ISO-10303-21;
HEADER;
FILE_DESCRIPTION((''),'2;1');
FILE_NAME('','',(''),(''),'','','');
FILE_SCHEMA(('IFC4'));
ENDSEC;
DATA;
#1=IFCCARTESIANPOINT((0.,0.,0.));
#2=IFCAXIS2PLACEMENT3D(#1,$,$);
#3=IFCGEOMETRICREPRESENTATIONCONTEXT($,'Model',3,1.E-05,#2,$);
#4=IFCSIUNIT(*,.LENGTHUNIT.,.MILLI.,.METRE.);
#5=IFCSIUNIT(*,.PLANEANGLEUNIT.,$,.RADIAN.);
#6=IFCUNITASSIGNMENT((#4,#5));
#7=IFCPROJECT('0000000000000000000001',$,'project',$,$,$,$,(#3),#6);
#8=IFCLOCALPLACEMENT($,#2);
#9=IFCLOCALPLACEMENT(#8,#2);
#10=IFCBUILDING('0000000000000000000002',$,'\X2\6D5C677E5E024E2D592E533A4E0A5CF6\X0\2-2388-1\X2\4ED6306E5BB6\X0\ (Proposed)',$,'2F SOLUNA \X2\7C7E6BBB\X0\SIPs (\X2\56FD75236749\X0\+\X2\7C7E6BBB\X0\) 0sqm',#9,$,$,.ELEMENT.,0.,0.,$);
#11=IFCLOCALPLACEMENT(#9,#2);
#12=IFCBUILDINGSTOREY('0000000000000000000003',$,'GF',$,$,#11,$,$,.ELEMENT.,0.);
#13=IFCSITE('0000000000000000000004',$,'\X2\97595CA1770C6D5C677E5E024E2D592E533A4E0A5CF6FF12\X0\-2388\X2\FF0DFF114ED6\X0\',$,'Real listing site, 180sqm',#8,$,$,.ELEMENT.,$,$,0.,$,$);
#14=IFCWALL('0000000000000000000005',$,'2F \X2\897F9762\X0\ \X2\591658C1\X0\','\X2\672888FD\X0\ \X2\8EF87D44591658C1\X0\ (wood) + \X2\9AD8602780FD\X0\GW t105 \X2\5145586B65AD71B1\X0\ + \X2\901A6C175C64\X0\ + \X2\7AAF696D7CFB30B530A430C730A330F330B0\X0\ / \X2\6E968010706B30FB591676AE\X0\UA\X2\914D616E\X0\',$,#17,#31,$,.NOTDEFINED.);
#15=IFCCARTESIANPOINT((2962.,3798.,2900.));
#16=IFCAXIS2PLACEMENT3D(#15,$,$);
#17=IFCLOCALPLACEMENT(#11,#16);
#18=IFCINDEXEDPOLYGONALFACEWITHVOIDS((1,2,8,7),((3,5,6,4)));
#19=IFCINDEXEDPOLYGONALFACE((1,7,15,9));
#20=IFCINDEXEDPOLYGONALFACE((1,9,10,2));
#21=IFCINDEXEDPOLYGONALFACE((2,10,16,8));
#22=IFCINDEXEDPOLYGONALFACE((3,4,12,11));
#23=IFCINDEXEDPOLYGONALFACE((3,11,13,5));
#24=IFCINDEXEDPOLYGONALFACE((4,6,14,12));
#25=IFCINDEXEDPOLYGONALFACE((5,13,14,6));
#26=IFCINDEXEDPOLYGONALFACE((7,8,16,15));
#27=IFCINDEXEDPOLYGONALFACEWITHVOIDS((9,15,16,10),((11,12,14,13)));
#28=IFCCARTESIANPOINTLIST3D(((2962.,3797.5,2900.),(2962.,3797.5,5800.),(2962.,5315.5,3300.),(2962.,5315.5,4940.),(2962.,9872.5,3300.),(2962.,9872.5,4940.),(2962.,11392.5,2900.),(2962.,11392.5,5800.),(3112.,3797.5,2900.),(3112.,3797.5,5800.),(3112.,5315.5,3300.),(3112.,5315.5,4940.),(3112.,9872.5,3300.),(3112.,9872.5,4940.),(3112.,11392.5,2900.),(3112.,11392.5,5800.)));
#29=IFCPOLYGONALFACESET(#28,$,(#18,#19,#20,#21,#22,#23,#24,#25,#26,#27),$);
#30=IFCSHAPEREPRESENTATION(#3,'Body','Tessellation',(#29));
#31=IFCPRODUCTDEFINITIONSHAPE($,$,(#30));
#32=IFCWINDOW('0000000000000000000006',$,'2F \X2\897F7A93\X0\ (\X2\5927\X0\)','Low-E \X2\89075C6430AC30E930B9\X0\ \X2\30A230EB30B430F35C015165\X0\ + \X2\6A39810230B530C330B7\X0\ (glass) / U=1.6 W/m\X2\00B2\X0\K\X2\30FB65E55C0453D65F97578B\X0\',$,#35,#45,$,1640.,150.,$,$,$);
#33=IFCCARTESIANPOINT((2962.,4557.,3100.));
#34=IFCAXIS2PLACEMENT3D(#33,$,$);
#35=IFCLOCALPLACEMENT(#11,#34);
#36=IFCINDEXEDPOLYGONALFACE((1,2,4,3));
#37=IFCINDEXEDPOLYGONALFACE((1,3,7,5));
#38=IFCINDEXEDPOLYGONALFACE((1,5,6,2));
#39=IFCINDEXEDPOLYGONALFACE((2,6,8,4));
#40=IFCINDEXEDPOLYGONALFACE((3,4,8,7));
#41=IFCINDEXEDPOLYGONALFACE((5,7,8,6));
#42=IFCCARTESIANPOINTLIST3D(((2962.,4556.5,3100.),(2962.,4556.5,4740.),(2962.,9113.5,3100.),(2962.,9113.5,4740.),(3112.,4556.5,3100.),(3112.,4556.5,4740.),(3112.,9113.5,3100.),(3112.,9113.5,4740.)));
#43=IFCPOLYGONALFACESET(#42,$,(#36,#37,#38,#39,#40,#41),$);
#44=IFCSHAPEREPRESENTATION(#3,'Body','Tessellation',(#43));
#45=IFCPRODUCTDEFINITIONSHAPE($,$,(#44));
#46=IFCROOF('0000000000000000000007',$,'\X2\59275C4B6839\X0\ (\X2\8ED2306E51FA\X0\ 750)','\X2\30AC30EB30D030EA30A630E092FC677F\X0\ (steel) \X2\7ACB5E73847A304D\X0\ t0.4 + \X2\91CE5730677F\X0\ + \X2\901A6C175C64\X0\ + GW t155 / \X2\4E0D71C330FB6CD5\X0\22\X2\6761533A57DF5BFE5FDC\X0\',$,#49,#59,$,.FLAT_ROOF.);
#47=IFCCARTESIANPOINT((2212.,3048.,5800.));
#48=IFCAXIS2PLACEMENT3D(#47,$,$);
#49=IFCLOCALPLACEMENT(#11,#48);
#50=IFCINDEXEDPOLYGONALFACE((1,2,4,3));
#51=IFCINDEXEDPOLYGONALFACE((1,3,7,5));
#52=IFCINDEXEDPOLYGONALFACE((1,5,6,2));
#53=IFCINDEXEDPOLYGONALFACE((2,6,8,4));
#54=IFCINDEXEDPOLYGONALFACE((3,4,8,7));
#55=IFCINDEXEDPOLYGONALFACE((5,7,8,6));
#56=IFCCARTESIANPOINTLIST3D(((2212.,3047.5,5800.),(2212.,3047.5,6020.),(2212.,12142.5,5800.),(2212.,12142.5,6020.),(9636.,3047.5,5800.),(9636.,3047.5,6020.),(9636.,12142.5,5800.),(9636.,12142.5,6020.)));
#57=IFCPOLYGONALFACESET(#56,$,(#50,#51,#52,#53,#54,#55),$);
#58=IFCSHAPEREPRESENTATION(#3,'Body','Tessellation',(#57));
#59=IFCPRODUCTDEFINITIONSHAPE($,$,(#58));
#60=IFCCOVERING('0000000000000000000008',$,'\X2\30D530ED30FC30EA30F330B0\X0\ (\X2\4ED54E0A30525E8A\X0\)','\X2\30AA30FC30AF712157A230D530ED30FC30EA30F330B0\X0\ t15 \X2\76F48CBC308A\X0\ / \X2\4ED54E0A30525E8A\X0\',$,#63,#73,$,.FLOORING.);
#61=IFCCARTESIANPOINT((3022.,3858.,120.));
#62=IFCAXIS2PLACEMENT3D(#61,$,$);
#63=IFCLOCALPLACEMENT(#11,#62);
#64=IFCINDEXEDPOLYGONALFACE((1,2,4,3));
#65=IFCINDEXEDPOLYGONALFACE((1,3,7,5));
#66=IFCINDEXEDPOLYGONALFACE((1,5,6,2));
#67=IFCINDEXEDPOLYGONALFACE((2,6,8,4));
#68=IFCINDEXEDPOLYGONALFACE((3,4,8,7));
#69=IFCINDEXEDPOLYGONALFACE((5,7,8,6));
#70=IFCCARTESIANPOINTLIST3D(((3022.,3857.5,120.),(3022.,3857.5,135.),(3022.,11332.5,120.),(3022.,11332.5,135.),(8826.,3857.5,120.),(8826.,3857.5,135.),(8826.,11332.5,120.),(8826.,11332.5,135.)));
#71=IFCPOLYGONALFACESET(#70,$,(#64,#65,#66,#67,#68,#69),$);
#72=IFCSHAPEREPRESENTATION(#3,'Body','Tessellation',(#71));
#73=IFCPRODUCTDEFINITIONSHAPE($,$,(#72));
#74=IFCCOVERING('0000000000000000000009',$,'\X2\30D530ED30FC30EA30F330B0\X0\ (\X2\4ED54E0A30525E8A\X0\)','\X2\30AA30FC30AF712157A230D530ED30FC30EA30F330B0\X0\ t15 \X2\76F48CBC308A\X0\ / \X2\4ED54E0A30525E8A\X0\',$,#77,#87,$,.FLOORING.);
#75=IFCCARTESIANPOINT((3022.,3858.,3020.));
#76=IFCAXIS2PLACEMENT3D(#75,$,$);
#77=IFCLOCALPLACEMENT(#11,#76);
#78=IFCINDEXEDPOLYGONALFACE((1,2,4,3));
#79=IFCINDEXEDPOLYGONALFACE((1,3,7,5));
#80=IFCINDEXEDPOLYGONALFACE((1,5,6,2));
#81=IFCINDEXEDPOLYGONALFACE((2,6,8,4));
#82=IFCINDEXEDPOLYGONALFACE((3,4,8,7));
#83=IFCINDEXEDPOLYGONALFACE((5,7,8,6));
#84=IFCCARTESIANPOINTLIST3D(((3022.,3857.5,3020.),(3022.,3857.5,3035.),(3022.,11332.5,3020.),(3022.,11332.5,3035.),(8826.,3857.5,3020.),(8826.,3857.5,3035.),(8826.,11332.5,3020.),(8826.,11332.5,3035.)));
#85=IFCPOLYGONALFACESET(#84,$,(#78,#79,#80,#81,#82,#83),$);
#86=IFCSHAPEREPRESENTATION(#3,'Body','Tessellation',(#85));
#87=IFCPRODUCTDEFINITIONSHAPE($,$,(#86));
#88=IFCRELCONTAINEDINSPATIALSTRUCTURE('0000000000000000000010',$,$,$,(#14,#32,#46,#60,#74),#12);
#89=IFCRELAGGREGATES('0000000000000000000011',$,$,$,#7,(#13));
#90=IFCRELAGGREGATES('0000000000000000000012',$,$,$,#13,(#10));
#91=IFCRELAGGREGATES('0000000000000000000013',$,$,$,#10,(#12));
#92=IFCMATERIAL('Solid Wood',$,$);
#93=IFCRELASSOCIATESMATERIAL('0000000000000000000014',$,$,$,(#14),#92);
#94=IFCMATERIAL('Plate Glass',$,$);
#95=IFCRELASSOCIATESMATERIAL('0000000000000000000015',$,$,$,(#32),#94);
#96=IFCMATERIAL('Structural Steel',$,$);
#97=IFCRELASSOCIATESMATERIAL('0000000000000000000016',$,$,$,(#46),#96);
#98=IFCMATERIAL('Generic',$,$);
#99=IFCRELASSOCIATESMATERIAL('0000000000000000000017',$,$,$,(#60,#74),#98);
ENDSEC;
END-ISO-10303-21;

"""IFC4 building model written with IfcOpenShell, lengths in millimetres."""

from ifc_helpers import new_model, si_unit, frame, frame_2d, origin, place, context, project, spatial, rectangle, extrude, material, element, fill, save


model = new_model("IFC4")

# Units and contexts
model_context = context("Model", 3, precision=1e-05, world=origin())
ifc_project = project(units=[si_unit("LENGTHUNIT", "METRE", prefix="MILLI"), si_unit("PLANEANGLEUNIT", "RADIAN")], contexts=[model_context])

# Site, building, storey
site_placement = place(None, origin())
site = spatial("IfcSite", under=ifc_project, at=site_placement, Name="静岡県浜松市中央区上島２-2388－１他", ObjectType="Real listing site, 180sqm", CompositionType="ELEMENT", RefElevation=0.0)
building_placement = place(site_placement, origin())
building = spatial("IfcBuilding", under=site, at=building_placement, Name="浜松市中央区上島2-2388-1他の家 (Proposed)", ObjectType="2F SOLUNA 籾殻SIPs (国産杉+籾殻) 0sqm", CompositionType="ELEMENT", ElevationOfRefHeight=0.0, ElevationOfTerrain=0.0)
storey_placement = place(building_placement, origin())
storey = spatial("IfcBuildingStorey", under=building, at=storey_placement, Name="GF", CompositionType="ELEMENT", Elevation=0.0)

# Shared definitions
ifc_material_1 = material(Name="Solid Wood")

# Shared definitions
ifc_material_2 = material(Name="Plate Glass")

# Wall, opening, window
wall_1_placement = place(storey_placement, frame((2962.0, 3798.0, 2900.0)))
wall_1 = element("IfcWall", 1, at=wall_1_placement, inside=storey, material=ifc_material_1, Name="2F 西面 外壁", Description="木製 軸組外壁 (wood) + 高性能GW t105 充填断熱 + 通気層 + 窯業系サイディング / 準耐火・外皮UA配慮", PredefinedType="NOTDEFINED", context=model_context, shape_type="SweptSolid", body=[
    extrude(rectangle(XDim=150.0, YDim=7595.0, at=frame_2d((75.0, 3797.0))), frame((2962.0, 3798.0, 2900.0)), (0.0, 0.0, 1.0), 2900.0),
])
opening_1_placement = place(storey_placement, frame((2962.0, 4557.0, 3100.0)))
opening_1 = element("IfcOpeningElement", 2, at=opening_1_placement, cuts=wall_1, PredefinedType="NOTDEFINED", context=model_context, shape_type="SweptSolid", body=[
    extrude(rectangle(XDim=150.0, YDim=4557.0, at=frame_2d((75.0, 2278.0))), frame((2962.0, 4557.0, 3100.0)), (0.0, 0.0, 1.0), 1640.0),
])
window_1_placement = place(storey_placement, frame((2962.0, 4557.0, 3100.0)))
window_1 = element("IfcWindow", 3, at=window_1_placement, inside=storey, material=ifc_material_2, Name="2F 西窓 (大)", Description="Low-E 複層ガラス アルゴン封入 + 樹脂サッシ (glass) / U=1.6 W/m²K・日射取得型", OverallHeight=1640.0, OverallWidth=150.0, context=model_context, shape_type="SweptSolid", body=[
    extrude(rectangle(XDim=150.0, YDim=4557.0, at=frame_2d((75.0, 2278.0))), frame((2962.0, 4557.0, 3100.0)), (0.0, 0.0, 1.0), 1640.0),
])
fill(opening_1, window_1)

# Roof
ifc_material_3 = material(Name="Structural Steel")
roof_placement = place(storey_placement, frame((2212.0, 3048.0, 5800.0)))
element("IfcRoof", 4, at=roof_placement, inside=storey, material=ifc_material_3, Name="大屋根 (軒の出 750)", Description="ガルバリウム鋼板 (steel) 立平葺き t0.4 + 野地板 + 通気層 + GW t155 / 不燃・法22条区域対応", PredefinedType="FLAT_ROOF", context=model_context, shape_type="SweptSolid", body=[
    extrude(rectangle(XDim=7424.0, YDim=9095.0, at=frame_2d((3712.0, 4547.0))), frame((2212.0, 3048.0, 5800.0)), (0.0, 0.0, 1.0), 220.0),
])

# Coverings
ifc_material_4 = material(Name="Generic")
covering_1_placement = place(storey_placement, frame((3022.0, 3858.0, 120.0)))
element("IfcCovering", 5, at=covering_1_placement, inside=storey, material=ifc_material_4, Name="フローリング (仕上げ床)", Description="オーク無垢フローリング t15 直貼り / 仕上げ床", PredefinedType="FLOORING", context=model_context, shape_type="SweptSolid", body=[
    extrude(rectangle(XDim=5804.0, YDim=7475.0, at=frame_2d((2902.0, 3737.0))), frame((3022.0, 3858.0, 120.0)), (0.0, 0.0, 1.0), 15.0),
])
covering_2_placement = place(storey_placement, frame((3022.0, 3858.0, 3020.0)))
element("IfcCovering", 6, at=covering_2_placement, inside=storey, material=ifc_material_4, Name="フローリング (仕上げ床)", Description="オーク無垢フローリング t15 直貼り / 仕上げ床", PredefinedType="FLOORING", context=model_context, shape_type="SweptSolid", body=[
    extrude(rectangle(XDim=5804.0, YDim=7475.0, at=frame_2d((2902.0, 3737.0))), frame((3022.0, 3858.0, 3020.0)), (0.0, 0.0, 1.0), 15.0),
])

save(model, "model.ifc")
